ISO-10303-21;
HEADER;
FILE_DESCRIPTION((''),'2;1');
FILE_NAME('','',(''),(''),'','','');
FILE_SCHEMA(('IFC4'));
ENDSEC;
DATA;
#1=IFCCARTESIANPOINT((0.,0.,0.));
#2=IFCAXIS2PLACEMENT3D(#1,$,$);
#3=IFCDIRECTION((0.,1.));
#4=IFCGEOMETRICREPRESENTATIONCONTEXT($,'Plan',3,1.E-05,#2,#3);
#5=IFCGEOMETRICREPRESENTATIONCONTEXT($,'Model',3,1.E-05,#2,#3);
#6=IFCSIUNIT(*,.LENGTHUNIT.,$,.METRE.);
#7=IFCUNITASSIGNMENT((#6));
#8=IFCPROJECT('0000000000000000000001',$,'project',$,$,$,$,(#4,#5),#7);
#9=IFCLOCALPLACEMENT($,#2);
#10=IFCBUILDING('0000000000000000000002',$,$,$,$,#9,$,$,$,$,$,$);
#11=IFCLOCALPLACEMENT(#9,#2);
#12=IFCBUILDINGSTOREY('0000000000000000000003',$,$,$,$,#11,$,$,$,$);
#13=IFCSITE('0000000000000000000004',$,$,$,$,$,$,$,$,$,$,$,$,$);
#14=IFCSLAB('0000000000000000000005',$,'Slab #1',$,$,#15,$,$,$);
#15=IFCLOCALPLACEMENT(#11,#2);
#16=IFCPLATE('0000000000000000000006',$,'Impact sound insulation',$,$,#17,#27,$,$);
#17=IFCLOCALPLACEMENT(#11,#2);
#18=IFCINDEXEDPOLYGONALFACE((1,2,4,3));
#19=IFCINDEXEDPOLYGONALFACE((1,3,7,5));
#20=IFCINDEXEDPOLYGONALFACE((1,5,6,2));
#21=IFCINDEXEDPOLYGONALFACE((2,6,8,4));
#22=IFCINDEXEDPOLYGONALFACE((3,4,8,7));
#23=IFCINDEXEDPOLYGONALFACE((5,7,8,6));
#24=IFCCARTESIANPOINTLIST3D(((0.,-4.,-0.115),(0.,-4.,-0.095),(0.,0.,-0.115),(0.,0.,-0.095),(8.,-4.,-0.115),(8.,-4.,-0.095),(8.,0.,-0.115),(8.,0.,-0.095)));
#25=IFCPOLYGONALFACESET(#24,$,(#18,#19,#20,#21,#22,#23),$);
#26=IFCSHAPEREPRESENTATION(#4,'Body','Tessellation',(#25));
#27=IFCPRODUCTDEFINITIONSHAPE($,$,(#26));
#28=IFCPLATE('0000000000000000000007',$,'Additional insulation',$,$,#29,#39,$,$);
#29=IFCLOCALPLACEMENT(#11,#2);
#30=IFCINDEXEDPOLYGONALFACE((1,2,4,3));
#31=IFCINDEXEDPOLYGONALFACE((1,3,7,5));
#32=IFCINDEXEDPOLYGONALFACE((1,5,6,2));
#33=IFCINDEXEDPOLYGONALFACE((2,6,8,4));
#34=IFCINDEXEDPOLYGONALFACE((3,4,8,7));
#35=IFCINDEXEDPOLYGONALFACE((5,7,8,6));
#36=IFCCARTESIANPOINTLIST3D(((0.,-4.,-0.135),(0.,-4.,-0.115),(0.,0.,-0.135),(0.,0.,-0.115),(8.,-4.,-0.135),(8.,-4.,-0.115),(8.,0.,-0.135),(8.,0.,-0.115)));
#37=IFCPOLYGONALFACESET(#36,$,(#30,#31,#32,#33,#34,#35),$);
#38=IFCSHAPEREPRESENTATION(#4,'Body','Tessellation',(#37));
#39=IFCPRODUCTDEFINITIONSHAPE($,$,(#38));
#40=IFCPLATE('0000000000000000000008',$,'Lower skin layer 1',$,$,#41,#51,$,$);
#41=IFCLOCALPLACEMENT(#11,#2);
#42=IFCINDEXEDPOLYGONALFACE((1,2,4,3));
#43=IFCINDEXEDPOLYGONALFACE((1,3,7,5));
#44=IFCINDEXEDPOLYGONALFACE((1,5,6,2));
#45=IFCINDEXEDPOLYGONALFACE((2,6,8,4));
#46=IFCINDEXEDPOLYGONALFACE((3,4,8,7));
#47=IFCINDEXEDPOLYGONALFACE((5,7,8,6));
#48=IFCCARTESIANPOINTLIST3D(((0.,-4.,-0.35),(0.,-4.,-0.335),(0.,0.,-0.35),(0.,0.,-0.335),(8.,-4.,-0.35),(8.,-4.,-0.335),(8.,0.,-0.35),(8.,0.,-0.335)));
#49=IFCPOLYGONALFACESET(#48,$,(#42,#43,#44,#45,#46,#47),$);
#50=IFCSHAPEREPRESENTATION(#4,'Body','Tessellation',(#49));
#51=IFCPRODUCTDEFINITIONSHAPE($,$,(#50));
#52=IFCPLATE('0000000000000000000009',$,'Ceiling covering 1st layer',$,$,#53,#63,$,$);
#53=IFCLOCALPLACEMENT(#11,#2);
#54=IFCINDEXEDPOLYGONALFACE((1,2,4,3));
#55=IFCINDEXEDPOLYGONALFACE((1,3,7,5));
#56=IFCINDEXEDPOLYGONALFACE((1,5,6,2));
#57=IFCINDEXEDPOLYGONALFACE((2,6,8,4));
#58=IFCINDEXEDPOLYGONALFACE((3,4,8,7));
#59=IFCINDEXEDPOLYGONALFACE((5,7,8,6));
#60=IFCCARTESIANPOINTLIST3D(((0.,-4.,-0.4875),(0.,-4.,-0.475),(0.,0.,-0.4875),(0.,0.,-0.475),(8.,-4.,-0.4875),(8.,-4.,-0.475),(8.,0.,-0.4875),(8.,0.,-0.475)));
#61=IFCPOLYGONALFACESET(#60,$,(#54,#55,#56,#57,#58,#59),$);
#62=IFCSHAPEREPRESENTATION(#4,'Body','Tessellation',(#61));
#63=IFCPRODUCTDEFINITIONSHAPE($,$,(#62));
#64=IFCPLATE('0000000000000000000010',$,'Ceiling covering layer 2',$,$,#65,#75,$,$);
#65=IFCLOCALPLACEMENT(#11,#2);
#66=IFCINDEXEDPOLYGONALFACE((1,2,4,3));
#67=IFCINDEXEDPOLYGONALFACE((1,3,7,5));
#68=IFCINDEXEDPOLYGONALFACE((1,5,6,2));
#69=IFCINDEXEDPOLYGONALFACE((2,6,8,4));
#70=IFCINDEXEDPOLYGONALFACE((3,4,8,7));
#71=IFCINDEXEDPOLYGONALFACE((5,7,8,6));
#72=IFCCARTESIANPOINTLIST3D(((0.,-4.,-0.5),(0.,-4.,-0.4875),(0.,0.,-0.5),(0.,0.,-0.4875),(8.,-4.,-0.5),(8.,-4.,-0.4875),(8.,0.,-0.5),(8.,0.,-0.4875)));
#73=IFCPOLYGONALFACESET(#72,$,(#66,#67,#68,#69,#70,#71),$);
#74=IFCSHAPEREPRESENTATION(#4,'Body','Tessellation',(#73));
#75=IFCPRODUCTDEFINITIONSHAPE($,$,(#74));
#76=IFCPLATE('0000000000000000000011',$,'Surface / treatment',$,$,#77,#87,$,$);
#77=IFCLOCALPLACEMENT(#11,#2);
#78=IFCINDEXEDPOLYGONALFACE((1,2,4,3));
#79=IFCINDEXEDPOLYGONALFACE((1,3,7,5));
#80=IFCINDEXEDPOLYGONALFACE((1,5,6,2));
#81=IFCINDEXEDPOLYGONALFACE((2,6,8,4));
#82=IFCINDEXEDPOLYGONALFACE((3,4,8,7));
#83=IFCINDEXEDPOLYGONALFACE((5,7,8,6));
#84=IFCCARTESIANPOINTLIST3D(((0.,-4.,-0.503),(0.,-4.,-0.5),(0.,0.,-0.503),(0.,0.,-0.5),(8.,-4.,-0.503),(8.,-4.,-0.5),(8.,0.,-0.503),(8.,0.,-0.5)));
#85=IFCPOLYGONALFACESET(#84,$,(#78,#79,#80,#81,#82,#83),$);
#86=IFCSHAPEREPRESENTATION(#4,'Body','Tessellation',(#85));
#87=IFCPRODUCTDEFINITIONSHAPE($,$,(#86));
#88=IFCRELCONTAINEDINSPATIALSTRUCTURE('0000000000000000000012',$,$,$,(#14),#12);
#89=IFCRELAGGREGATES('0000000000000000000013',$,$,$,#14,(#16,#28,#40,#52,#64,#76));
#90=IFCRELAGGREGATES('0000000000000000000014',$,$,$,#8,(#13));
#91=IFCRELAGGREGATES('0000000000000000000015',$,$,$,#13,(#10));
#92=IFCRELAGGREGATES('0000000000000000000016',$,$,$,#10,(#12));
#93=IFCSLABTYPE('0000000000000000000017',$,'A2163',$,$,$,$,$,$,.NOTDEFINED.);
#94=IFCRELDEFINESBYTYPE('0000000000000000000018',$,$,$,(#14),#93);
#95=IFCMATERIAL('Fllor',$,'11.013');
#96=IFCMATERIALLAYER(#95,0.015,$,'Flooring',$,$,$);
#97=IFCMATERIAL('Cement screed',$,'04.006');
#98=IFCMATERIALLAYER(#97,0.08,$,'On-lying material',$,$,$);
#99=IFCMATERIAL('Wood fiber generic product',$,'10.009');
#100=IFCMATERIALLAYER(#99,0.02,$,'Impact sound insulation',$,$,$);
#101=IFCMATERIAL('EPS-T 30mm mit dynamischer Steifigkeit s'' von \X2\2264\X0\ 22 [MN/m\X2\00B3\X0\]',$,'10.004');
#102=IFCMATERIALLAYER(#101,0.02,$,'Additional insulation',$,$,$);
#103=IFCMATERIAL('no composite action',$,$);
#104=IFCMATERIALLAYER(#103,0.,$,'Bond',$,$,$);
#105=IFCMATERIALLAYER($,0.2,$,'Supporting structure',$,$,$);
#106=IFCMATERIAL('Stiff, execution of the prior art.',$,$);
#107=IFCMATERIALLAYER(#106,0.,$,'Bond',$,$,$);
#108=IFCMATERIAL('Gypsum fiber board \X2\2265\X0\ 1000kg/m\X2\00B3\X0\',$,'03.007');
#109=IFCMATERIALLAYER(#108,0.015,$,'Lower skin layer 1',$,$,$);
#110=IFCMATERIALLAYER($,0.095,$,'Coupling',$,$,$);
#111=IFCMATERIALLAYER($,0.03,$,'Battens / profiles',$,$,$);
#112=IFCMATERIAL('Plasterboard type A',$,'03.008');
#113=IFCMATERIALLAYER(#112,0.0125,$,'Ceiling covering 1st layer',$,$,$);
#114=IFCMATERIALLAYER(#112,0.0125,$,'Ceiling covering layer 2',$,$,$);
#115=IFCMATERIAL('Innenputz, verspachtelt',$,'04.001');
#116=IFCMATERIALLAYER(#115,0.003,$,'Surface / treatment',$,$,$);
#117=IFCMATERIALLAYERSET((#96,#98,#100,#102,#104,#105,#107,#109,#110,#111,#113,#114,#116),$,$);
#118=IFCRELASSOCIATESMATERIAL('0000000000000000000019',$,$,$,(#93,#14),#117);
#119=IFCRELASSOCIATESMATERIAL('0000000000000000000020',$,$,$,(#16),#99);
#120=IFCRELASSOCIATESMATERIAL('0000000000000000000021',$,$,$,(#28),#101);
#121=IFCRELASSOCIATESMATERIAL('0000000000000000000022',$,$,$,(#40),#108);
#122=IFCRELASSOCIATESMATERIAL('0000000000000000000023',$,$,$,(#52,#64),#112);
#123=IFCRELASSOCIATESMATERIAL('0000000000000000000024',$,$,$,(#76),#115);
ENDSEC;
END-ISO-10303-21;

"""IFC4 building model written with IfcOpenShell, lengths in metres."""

from ifc_helpers import new_model, si_unit, direction, frame, frame_2d, origin, place, context, project, spatial, rectangle, extrude, material, layer, layer_set, type_object, element, aggregate, save


model = new_model("IFC4")

# Units and contexts
plan_context = context("Plan", 3, precision=1e-05, world=origin(), true_north=direction((0.0, 1.0)))
model_context = context("Model", 3, precision=1e-05, world=origin(), true_north=direction((0.0, 1.0)))
ifc_project = project(units=[si_unit("LENGTHUNIT", "METRE")], contexts=[plan_context, model_context])

# Site, building, storey
site = spatial("IfcSite", under=ifc_project)
building_placement = place(None, origin())
building = spatial("IfcBuilding", under=site, at=building_placement)
storey_placement = place(building_placement, origin())
storey = spatial("IfcBuildingStorey", under=building, at=storey_placement)

# Slab, plates
ifc_material_1 = material(Name="Fllor", Category="11.013")
ifc_layer_1 = layer(ifc_material_1, 0.015, Name="Flooring")
ifc_material_2 = material(Name="Cement screed", Category="04.006")
ifc_layer_2 = layer(ifc_material_2, 0.08, Name="On-lying material")
ifc_material_3 = material(Name="Wood fiber generic product", Category="10.009")
ifc_layer_3 = layer(ifc_material_3, 0.02, Name="Impact sound insulation")
ifc_material_4 = material(Name="EPS-T 30mm mit dynamischer Steifigkeit s' von ≤ 22 [MN/m³]", Category="10.004")
ifc_layer_4 = layer(ifc_material_4, 0.02, Name="Additional insulation")
ifc_material_5 = material(Name="no composite action")
ifc_layer_5 = layer(ifc_material_5, 0.0, Name="Bond")
ifc_layer_6 = layer(None, 0.2, Name="Supporting structure")
ifc_material_6 = material(Name="Stiff, execution of the prior art.")
ifc_layer_7 = layer(ifc_material_6, 0.0, Name="Bond")
ifc_material_7 = material(Name="Gypsum fiber board ≥ 1000kg/m³", Category="03.007")
ifc_layer_8 = layer(ifc_material_7, 0.015, Name="Lower skin layer 1")
ifc_layer_9 = layer(None, 0.095, Name="Coupling")
ifc_layer_10 = layer(None, 0.03, Name="Battens / profiles")
ifc_material_8 = material(Name="Plasterboard type A", Category="03.008")
ifc_layer_11 = layer(ifc_material_8, 0.0125, Name="Ceiling covering 1st layer")
ifc_layer_12 = layer(ifc_material_8, 0.0125, Name="Ceiling covering layer 2")
ifc_material_9 = material(Name="Innenputz, verspachtelt", Category="04.001")
ifc_layer_13 = layer(ifc_material_9, 0.003, Name="Surface / treatment")
ifc_layer_set = layer_set([ifc_layer_1, ifc_layer_2, ifc_layer_3, ifc_layer_4, ifc_layer_5, ifc_layer_6, ifc_layer_7, ifc_layer_8, ifc_layer_9, ifc_layer_10, ifc_layer_11, ifc_layer_12, ifc_layer_13])
slab_type = type_object("IfcSlabType", Name="A2163", PredefinedType="NOTDEFINED", material=ifc_layer_set)
slab_placement = place(None, frame((0.0, 0.0, 0.0), z_axis=(0.0, 0.0, -1.0), x_axis=(1.0, 0.0, 0.0)))
slab = element("IfcSlab", 1, at=slab_placement, inside=storey, type_object=slab_type, material=ifc_layer_set, Name="Slab #1")
plate_1_placement = place(slab_placement, origin())
plate_1 = element("IfcPlate", 2, at=plate_1_placement, material=ifc_material_3, Name="Impact sound insulation", context=plan_context, shape_type="SweptSolid", body=[
    extrude(rectangle(XDim=8.0, YDim=4.0, at=frame_2d((4.0, 2.0), x_axis=(1.0, 0.0))), frame((0.0, 0.0, 0.095), z_axis=(0.0, 0.0, 1.0), x_axis=(1.0, 0.0, 0.0)), (0.0, 0.0, 1.0), 0.02),
])
plate_2_placement = place(slab_placement, origin())
plate_2 = element("IfcPlate", 3, at=plate_2_placement, material=ifc_material_4, Name="Additional insulation", context=plan_context, shape_type="SweptSolid", body=[
    extrude(rectangle(XDim=8.0, YDim=4.0, at=frame_2d((4.0, 2.0), x_axis=(1.0, 0.0))), frame((0.0, 0.0, 0.115), z_axis=(0.0, 0.0, 1.0), x_axis=(1.0, 0.0, 0.0)), (0.0, 0.0, 1.0), 0.02),
])
plate_3_placement = place(slab_placement, origin())
plate_3 = element("IfcPlate", 4, at=plate_3_placement, material=ifc_material_7, Name="Lower skin layer 1", context=plan_context, shape_type="SweptSolid", body=[
    extrude(rectangle(XDim=8.0, YDim=4.0, at=frame_2d((4.0, 2.0), x_axis=(1.0, 0.0))), frame((0.0, 0.0, 0.335), z_axis=(0.0, 0.0, 1.0), x_axis=(1.0, 0.0, 0.0)), (0.0, 0.0, 1.0), 0.015),
])
plate_4_placement = place(slab_placement, origin())
plate_4 = element("IfcPlate", 5, at=plate_4_placement, material=ifc_material_8, Name="Ceiling covering 1st layer", context=plan_context, shape_type="SweptSolid", body=[
    extrude(rectangle(XDim=8.0, YDim=4.0, at=frame_2d((4.0, 2.0), x_axis=(1.0, 0.0))), frame((0.0, 0.0, 0.475), z_axis=(0.0, 0.0, 1.0), x_axis=(1.0, 0.0, 0.0)), (0.0, 0.0, 1.0), 0.0125),
])
plate_5_placement = place(slab_placement, origin())
plate_5 = element("IfcPlate", 6, at=plate_5_placement, material=ifc_material_8, Name="Ceiling covering layer 2", context=plan_context, shape_type="SweptSolid", body=[
    extrude(rectangle(XDim=8.0, YDim=4.0, at=frame_2d((4.0, 2.0), x_axis=(1.0, 0.0))), frame((0.0, 0.0, 0.4875), z_axis=(0.0, 0.0, 1.0), x_axis=(1.0, 0.0, 0.0)), (0.0, 0.0, 1.0), 0.0125),
])
plate_6_placement = place(slab_placement, origin())
plate_6 = element("IfcPlate", 7, at=plate_6_placement, material=ifc_material_9, Name="Surface / treatment", context=plan_context, shape_type="SweptSolid", body=[
    extrude(rectangle(XDim=8.0, YDim=4.0, at=frame_2d((4.0, 2.0), x_axis=(1.0, 0.0))), frame((0.0, 0.0, 0.5), z_axis=(0.0, 0.0, 1.0), x_axis=(1.0, 0.0, 0.0)), (0.0, 0.0, 1.0), 0.003),
])
aggregate(slab, [plate_1, plate_2, plate_3, plate_4, plate_5, plate_6])

save(model, "model.ifc")
